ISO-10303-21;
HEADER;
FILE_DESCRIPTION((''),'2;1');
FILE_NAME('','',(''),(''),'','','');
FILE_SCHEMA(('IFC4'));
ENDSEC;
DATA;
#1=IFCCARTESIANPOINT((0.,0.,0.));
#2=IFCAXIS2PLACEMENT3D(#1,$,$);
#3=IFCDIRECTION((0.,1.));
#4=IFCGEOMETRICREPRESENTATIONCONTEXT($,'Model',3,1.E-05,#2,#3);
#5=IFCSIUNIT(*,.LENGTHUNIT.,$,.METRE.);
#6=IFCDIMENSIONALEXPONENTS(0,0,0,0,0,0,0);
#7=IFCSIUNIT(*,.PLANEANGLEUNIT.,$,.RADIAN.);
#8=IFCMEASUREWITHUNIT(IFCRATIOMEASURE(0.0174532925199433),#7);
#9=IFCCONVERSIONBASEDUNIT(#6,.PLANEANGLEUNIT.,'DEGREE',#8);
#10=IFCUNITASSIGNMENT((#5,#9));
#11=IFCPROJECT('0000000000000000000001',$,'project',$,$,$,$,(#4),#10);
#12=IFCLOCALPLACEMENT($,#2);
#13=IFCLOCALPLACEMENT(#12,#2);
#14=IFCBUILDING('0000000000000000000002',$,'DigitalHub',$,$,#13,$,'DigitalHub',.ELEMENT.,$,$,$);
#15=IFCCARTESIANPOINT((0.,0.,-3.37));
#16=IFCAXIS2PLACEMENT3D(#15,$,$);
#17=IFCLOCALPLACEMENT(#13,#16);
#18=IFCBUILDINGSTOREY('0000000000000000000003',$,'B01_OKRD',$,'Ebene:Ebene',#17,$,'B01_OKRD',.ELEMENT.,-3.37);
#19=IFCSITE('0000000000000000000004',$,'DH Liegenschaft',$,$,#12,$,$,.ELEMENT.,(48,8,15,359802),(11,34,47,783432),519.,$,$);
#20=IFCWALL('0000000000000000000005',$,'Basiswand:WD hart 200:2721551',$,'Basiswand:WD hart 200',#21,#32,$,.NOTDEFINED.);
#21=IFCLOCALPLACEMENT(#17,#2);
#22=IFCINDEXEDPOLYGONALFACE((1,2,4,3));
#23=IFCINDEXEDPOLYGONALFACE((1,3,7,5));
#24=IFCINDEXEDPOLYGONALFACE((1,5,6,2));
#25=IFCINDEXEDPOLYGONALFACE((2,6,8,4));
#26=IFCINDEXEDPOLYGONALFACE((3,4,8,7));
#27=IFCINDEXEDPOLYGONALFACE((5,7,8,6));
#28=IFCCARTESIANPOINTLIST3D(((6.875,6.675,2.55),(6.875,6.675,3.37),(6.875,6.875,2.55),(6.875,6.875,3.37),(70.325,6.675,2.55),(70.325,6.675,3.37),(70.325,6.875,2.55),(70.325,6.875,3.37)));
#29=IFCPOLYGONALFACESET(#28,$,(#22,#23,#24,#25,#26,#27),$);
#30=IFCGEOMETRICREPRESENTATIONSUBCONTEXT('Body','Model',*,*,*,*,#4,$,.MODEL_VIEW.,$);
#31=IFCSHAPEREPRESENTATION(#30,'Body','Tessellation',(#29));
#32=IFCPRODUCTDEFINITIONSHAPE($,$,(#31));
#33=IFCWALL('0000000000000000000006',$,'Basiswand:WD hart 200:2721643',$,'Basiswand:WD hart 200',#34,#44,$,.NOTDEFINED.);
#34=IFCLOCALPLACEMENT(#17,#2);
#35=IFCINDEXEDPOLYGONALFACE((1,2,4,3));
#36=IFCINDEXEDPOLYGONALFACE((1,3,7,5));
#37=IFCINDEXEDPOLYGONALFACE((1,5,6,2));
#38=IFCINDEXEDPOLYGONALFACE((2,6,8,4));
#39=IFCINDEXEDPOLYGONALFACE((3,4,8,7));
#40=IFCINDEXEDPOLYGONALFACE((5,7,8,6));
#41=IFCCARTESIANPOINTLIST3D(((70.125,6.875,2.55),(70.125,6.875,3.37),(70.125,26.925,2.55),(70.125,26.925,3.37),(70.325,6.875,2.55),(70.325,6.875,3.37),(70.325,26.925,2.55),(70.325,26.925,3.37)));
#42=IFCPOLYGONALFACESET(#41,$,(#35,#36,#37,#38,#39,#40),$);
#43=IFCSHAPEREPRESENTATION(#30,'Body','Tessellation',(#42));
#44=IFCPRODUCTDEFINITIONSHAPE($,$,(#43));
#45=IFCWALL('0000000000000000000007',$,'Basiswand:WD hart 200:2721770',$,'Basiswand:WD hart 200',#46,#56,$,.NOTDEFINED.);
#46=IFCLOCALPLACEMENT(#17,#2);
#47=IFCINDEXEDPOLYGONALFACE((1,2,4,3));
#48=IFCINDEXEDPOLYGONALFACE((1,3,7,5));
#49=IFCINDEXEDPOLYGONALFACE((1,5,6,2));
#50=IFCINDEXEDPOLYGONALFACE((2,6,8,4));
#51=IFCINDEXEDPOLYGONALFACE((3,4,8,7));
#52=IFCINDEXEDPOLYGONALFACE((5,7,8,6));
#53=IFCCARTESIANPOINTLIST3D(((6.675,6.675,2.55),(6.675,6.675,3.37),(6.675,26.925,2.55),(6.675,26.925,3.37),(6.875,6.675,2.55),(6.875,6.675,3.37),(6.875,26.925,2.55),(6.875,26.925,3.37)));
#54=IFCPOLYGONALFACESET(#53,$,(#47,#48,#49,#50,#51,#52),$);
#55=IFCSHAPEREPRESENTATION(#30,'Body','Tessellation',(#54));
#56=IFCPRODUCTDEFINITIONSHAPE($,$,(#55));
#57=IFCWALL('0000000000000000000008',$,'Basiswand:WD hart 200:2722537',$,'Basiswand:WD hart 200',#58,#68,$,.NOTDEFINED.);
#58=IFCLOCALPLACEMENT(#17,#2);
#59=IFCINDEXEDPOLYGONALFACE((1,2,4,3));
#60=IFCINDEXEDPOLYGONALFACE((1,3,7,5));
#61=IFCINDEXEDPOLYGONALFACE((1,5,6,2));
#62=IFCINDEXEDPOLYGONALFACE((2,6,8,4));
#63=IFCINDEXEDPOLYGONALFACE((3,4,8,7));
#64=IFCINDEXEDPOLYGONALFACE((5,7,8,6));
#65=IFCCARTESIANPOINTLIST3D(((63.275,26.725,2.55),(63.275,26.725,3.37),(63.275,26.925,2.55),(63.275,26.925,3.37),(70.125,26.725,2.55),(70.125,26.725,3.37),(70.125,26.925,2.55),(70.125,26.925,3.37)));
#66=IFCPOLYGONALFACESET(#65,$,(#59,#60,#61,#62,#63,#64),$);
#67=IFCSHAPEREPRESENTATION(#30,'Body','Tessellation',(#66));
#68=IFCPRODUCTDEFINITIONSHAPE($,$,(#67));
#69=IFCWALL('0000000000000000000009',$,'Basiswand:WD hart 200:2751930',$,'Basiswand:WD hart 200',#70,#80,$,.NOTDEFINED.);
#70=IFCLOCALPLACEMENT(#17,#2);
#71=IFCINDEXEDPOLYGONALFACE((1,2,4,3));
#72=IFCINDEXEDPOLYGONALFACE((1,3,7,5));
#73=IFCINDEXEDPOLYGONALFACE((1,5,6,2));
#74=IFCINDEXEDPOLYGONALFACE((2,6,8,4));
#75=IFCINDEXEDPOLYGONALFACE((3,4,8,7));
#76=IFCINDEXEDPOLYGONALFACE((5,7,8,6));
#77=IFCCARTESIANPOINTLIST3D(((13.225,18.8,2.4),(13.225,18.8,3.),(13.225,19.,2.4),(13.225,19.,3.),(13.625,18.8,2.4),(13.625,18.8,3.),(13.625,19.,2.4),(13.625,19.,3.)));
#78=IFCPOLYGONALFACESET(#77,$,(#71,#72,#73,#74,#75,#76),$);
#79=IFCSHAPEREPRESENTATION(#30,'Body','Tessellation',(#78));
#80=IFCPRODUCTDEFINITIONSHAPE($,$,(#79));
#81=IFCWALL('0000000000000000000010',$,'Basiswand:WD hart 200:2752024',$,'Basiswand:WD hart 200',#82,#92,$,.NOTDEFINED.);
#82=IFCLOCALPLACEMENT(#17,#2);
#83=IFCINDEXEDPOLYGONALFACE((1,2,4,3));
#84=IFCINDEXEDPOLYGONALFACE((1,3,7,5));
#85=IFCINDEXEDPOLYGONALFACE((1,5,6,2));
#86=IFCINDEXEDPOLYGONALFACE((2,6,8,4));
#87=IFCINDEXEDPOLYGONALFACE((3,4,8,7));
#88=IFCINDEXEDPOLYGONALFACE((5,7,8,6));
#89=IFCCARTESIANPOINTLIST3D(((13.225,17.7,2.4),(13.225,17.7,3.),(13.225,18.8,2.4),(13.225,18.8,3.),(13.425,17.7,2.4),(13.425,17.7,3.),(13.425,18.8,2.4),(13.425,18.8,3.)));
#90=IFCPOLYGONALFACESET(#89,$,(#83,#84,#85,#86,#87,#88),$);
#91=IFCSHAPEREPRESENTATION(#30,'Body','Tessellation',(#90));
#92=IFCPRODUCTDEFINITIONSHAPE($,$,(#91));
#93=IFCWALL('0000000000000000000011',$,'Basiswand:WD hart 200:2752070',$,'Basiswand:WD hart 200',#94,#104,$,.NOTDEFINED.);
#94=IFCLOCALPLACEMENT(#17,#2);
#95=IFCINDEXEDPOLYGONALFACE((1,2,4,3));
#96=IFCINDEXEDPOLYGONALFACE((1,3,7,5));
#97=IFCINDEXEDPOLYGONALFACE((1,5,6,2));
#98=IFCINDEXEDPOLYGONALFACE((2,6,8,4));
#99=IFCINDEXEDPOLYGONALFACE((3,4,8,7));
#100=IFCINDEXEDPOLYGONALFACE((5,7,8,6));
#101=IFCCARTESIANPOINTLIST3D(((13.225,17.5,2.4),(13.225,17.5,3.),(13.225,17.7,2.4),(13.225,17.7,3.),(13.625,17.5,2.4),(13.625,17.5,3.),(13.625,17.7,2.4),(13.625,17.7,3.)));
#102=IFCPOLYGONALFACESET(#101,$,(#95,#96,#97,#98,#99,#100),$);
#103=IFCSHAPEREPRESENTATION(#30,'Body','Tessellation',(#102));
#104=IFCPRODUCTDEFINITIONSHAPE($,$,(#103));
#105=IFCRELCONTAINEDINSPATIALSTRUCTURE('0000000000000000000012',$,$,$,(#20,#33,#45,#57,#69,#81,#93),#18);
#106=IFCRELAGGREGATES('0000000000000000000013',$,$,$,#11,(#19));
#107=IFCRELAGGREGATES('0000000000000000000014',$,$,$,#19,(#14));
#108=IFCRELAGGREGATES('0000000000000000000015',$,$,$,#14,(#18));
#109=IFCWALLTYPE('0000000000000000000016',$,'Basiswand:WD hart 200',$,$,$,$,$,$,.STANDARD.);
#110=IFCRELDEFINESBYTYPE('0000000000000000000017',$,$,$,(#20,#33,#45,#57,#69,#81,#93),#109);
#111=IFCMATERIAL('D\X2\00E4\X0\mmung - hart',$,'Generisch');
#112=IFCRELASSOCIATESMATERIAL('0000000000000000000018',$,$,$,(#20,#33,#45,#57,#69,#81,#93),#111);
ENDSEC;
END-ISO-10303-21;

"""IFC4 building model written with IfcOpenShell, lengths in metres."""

from ifc_helpers import new_model, entity, si_unit, converted_unit, direction, frame, origin, place, context, subcontext, project, spatial, indexed_curve, outline, extrude, material, type_object, element, save


model = new_model("IFC4")

# Units and contexts
model_context = context("Model", 3, precision=1e-05, world=origin(), true_north=direction((0.0, 1.0)))
body_context = subcontext(model_context, "Body", "Model", "MODEL_VIEW")
ifc_project = project(units=[si_unit("LENGTHUNIT", "METRE"), converted_unit("PLANEANGLEUNIT", "DEGREE", entity("IfcRatioMeasure", 0.0174532925199433), si_unit("PLANEANGLEUNIT", "RADIAN"), dimensions=[0, 0, 0, 0, 0, 0, 0])], contexts=[model_context])

# Site, building, storey
site_placement = place(None, frame((0.0, 0.0, 0.0)))
site = spatial("IfcSite", under=ifc_project, at=site_placement, Name="DH Liegenschaft", CompositionType="ELEMENT", RefLatitude=(48, 8, 15, 359802), RefLongitude=(11, 34, 47, 783432), RefElevation=519.0)
building_placement = place(site_placement, origin())
building = spatial("IfcBuilding", under=site, at=building_placement, Name="DigitalHub", LongName="DigitalHub", CompositionType="ELEMENT")
storey_placement = place(building_placement, frame((0.0, 0.0, -3.37)))
storey = spatial("IfcBuildingStorey", under=building, at=storey_placement, Name="B01_OKRD", ObjectType="Ebene:Ebene", LongName="B01_OKRD", CompositionType="ELEMENT", Elevation=-3.37)

# Shared definitions
ifc_material_1 = material(Name="Dämmung - hart", Category="Generisch")

# Walls
wall_type_1 = type_object("IfcWallType", Name="Basiswand:WD hart 200", PredefinedType="STANDARD")
wall_1_placement = place(storey_placement, frame((6.875, 6.775, 2.55)))
element("IfcWall", 1, at=wall_1_placement, inside=storey, type_object=wall_type_1, material=ifc_material_1, Name="Basiswand:WD hart 200:2721551", ObjectType="Basiswand:WD hart 200", PredefinedType="NOTDEFINED", context=body_context, shape_type="SweptSolid", body=[
    extrude(outline(indexed_curve([(63.45, 0.1), (0.0, 0.1), (0.0, -0.1), (63.45, -0.1), (63.45, 0.1)], self_intersect=False)), origin(), (0.0, 0.0, 1.0), 0.82),
])
wall_2_placement = place(storey_placement, frame((70.225, 6.875, 2.55), z_axis=(0.0, 0.0, 1.0), x_axis=(0.0, 1.0, 0.0)))
element("IfcWall", 2, at=wall_2_placement, inside=storey, type_object=wall_type_1, material=ifc_material_1, Name="Basiswand:WD hart 200:2721643", ObjectType="Basiswand:WD hart 200", PredefinedType="NOTDEFINED", context=body_context, shape_type="SweptSolid", body=[
    extrude(outline(indexed_curve([(20.05, 0.1), (0.0, 0.1), (0.0, -0.1), (20.05, -0.1), (20.05, 0.1)], self_intersect=False)), origin(), (0.0, 0.0, 1.0), 0.82),
])
wall_3_placement = place(storey_placement, frame((6.775, 6.675, 2.55), z_axis=(0.0, 0.0, 1.0), x_axis=(0.0, 1.0, 0.0)))
element("IfcWall", 3, at=wall_3_placement, inside=storey, type_object=wall_type_1, material=ifc_material_1, Name="Basiswand:WD hart 200:2721770", ObjectType="Basiswand:WD hart 200", PredefinedType="NOTDEFINED", context=body_context, shape_type="SweptSolid", body=[
    extrude(outline(indexed_curve([(20.25, 0.1), (0.0, 0.1), (0.0, -0.1), (20.25, -0.1), (20.25, 0.1)], self_intersect=False)), origin(), (0.0, 0.0, 1.0), 0.82),
])
wall_4_placement = place(storey_placement, frame((70.125, 26.825, 2.55), z_axis=(0.0, 0.0, 1.0), x_axis=(-1.0, 0.0, 0.0)))
element("IfcWall", 4, at=wall_4_placement, inside=storey, type_object=wall_type_1, material=ifc_material_1, Name="Basiswand:WD hart 200:2722537", ObjectType="Basiswand:WD hart 200", PredefinedType="NOTDEFINED", context=body_context, shape_type="SweptSolid", body=[
    extrude(outline(indexed_curve([(6.85, 0.1), (0.0, 0.1), (0.0, -0.1), (6.85, -0.1), (6.85, 0.1)], self_intersect=False)), origin(), (0.0, 0.0, 1.0), 0.82),
])
wall_5_placement = place(storey_placement, frame((13.625, 18.9, 2.4), z_axis=(0.0, 0.0, 1.0), x_axis=(-1.0, 0.0, 0.0)))
element("IfcWall", 5, at=wall_5_placement, inside=storey, type_object=wall_type_1, material=ifc_material_1, Name="Basiswand:WD hart 200:2751930", ObjectType="Basiswand:WD hart 200", PredefinedType="NOTDEFINED", context=body_context, shape_type="SweptSolid", body=[
    extrude(outline(indexed_curve([(0.4, 0.1), (0.0, 0.1), (0.0, -0.1), (0.4, -0.1), (0.4, 0.1)], self_intersect=False)), origin(), (0.0, 0.0, 1.0), 0.6),
])
wall_6_placement = place(storey_placement, frame((13.325, 18.8, 2.4), z_axis=(0.0, 0.0, 1.0), x_axis=(0.0, -1.0, 0.0)))
element("IfcWall", 6, at=wall_6_placement, inside=storey, type_object=wall_type_1, material=ifc_material_1, Name="Basiswand:WD hart 200:2752024", ObjectType="Basiswand:WD hart 200", PredefinedType="NOTDEFINED", context=body_context, shape_type="SweptSolid", body=[
    extrude(outline(indexed_curve([(1.1, 0.1), (0.0, 0.1), (0.0, -0.1), (1.1, -0.1), (1.1, 0.1)], self_intersect=False)), origin(), (0.0, 0.0, 1.0), 0.6),
])
wall_7_placement = place(storey_placement, frame((13.225, 17.6, 2.4)))
element("IfcWall", 7, at=wall_7_placement, inside=storey, type_object=wall_type_1, material=ifc_material_1, Name="Basiswand:WD hart 200:2752070", ObjectType="Basiswand:WD hart 200", PredefinedType="NOTDEFINED", context=body_context, shape_type="SweptSolid", body=[
    extrude(outline(indexed_curve([(0.4, 0.1), (0.0, 0.1), (0.0, -0.1), (0.4, -0.1), (0.4, 0.1)], self_intersect=False)), origin(), (0.0, 0.0, 1.0), 0.6),
])

save(model, "model.ifc")
